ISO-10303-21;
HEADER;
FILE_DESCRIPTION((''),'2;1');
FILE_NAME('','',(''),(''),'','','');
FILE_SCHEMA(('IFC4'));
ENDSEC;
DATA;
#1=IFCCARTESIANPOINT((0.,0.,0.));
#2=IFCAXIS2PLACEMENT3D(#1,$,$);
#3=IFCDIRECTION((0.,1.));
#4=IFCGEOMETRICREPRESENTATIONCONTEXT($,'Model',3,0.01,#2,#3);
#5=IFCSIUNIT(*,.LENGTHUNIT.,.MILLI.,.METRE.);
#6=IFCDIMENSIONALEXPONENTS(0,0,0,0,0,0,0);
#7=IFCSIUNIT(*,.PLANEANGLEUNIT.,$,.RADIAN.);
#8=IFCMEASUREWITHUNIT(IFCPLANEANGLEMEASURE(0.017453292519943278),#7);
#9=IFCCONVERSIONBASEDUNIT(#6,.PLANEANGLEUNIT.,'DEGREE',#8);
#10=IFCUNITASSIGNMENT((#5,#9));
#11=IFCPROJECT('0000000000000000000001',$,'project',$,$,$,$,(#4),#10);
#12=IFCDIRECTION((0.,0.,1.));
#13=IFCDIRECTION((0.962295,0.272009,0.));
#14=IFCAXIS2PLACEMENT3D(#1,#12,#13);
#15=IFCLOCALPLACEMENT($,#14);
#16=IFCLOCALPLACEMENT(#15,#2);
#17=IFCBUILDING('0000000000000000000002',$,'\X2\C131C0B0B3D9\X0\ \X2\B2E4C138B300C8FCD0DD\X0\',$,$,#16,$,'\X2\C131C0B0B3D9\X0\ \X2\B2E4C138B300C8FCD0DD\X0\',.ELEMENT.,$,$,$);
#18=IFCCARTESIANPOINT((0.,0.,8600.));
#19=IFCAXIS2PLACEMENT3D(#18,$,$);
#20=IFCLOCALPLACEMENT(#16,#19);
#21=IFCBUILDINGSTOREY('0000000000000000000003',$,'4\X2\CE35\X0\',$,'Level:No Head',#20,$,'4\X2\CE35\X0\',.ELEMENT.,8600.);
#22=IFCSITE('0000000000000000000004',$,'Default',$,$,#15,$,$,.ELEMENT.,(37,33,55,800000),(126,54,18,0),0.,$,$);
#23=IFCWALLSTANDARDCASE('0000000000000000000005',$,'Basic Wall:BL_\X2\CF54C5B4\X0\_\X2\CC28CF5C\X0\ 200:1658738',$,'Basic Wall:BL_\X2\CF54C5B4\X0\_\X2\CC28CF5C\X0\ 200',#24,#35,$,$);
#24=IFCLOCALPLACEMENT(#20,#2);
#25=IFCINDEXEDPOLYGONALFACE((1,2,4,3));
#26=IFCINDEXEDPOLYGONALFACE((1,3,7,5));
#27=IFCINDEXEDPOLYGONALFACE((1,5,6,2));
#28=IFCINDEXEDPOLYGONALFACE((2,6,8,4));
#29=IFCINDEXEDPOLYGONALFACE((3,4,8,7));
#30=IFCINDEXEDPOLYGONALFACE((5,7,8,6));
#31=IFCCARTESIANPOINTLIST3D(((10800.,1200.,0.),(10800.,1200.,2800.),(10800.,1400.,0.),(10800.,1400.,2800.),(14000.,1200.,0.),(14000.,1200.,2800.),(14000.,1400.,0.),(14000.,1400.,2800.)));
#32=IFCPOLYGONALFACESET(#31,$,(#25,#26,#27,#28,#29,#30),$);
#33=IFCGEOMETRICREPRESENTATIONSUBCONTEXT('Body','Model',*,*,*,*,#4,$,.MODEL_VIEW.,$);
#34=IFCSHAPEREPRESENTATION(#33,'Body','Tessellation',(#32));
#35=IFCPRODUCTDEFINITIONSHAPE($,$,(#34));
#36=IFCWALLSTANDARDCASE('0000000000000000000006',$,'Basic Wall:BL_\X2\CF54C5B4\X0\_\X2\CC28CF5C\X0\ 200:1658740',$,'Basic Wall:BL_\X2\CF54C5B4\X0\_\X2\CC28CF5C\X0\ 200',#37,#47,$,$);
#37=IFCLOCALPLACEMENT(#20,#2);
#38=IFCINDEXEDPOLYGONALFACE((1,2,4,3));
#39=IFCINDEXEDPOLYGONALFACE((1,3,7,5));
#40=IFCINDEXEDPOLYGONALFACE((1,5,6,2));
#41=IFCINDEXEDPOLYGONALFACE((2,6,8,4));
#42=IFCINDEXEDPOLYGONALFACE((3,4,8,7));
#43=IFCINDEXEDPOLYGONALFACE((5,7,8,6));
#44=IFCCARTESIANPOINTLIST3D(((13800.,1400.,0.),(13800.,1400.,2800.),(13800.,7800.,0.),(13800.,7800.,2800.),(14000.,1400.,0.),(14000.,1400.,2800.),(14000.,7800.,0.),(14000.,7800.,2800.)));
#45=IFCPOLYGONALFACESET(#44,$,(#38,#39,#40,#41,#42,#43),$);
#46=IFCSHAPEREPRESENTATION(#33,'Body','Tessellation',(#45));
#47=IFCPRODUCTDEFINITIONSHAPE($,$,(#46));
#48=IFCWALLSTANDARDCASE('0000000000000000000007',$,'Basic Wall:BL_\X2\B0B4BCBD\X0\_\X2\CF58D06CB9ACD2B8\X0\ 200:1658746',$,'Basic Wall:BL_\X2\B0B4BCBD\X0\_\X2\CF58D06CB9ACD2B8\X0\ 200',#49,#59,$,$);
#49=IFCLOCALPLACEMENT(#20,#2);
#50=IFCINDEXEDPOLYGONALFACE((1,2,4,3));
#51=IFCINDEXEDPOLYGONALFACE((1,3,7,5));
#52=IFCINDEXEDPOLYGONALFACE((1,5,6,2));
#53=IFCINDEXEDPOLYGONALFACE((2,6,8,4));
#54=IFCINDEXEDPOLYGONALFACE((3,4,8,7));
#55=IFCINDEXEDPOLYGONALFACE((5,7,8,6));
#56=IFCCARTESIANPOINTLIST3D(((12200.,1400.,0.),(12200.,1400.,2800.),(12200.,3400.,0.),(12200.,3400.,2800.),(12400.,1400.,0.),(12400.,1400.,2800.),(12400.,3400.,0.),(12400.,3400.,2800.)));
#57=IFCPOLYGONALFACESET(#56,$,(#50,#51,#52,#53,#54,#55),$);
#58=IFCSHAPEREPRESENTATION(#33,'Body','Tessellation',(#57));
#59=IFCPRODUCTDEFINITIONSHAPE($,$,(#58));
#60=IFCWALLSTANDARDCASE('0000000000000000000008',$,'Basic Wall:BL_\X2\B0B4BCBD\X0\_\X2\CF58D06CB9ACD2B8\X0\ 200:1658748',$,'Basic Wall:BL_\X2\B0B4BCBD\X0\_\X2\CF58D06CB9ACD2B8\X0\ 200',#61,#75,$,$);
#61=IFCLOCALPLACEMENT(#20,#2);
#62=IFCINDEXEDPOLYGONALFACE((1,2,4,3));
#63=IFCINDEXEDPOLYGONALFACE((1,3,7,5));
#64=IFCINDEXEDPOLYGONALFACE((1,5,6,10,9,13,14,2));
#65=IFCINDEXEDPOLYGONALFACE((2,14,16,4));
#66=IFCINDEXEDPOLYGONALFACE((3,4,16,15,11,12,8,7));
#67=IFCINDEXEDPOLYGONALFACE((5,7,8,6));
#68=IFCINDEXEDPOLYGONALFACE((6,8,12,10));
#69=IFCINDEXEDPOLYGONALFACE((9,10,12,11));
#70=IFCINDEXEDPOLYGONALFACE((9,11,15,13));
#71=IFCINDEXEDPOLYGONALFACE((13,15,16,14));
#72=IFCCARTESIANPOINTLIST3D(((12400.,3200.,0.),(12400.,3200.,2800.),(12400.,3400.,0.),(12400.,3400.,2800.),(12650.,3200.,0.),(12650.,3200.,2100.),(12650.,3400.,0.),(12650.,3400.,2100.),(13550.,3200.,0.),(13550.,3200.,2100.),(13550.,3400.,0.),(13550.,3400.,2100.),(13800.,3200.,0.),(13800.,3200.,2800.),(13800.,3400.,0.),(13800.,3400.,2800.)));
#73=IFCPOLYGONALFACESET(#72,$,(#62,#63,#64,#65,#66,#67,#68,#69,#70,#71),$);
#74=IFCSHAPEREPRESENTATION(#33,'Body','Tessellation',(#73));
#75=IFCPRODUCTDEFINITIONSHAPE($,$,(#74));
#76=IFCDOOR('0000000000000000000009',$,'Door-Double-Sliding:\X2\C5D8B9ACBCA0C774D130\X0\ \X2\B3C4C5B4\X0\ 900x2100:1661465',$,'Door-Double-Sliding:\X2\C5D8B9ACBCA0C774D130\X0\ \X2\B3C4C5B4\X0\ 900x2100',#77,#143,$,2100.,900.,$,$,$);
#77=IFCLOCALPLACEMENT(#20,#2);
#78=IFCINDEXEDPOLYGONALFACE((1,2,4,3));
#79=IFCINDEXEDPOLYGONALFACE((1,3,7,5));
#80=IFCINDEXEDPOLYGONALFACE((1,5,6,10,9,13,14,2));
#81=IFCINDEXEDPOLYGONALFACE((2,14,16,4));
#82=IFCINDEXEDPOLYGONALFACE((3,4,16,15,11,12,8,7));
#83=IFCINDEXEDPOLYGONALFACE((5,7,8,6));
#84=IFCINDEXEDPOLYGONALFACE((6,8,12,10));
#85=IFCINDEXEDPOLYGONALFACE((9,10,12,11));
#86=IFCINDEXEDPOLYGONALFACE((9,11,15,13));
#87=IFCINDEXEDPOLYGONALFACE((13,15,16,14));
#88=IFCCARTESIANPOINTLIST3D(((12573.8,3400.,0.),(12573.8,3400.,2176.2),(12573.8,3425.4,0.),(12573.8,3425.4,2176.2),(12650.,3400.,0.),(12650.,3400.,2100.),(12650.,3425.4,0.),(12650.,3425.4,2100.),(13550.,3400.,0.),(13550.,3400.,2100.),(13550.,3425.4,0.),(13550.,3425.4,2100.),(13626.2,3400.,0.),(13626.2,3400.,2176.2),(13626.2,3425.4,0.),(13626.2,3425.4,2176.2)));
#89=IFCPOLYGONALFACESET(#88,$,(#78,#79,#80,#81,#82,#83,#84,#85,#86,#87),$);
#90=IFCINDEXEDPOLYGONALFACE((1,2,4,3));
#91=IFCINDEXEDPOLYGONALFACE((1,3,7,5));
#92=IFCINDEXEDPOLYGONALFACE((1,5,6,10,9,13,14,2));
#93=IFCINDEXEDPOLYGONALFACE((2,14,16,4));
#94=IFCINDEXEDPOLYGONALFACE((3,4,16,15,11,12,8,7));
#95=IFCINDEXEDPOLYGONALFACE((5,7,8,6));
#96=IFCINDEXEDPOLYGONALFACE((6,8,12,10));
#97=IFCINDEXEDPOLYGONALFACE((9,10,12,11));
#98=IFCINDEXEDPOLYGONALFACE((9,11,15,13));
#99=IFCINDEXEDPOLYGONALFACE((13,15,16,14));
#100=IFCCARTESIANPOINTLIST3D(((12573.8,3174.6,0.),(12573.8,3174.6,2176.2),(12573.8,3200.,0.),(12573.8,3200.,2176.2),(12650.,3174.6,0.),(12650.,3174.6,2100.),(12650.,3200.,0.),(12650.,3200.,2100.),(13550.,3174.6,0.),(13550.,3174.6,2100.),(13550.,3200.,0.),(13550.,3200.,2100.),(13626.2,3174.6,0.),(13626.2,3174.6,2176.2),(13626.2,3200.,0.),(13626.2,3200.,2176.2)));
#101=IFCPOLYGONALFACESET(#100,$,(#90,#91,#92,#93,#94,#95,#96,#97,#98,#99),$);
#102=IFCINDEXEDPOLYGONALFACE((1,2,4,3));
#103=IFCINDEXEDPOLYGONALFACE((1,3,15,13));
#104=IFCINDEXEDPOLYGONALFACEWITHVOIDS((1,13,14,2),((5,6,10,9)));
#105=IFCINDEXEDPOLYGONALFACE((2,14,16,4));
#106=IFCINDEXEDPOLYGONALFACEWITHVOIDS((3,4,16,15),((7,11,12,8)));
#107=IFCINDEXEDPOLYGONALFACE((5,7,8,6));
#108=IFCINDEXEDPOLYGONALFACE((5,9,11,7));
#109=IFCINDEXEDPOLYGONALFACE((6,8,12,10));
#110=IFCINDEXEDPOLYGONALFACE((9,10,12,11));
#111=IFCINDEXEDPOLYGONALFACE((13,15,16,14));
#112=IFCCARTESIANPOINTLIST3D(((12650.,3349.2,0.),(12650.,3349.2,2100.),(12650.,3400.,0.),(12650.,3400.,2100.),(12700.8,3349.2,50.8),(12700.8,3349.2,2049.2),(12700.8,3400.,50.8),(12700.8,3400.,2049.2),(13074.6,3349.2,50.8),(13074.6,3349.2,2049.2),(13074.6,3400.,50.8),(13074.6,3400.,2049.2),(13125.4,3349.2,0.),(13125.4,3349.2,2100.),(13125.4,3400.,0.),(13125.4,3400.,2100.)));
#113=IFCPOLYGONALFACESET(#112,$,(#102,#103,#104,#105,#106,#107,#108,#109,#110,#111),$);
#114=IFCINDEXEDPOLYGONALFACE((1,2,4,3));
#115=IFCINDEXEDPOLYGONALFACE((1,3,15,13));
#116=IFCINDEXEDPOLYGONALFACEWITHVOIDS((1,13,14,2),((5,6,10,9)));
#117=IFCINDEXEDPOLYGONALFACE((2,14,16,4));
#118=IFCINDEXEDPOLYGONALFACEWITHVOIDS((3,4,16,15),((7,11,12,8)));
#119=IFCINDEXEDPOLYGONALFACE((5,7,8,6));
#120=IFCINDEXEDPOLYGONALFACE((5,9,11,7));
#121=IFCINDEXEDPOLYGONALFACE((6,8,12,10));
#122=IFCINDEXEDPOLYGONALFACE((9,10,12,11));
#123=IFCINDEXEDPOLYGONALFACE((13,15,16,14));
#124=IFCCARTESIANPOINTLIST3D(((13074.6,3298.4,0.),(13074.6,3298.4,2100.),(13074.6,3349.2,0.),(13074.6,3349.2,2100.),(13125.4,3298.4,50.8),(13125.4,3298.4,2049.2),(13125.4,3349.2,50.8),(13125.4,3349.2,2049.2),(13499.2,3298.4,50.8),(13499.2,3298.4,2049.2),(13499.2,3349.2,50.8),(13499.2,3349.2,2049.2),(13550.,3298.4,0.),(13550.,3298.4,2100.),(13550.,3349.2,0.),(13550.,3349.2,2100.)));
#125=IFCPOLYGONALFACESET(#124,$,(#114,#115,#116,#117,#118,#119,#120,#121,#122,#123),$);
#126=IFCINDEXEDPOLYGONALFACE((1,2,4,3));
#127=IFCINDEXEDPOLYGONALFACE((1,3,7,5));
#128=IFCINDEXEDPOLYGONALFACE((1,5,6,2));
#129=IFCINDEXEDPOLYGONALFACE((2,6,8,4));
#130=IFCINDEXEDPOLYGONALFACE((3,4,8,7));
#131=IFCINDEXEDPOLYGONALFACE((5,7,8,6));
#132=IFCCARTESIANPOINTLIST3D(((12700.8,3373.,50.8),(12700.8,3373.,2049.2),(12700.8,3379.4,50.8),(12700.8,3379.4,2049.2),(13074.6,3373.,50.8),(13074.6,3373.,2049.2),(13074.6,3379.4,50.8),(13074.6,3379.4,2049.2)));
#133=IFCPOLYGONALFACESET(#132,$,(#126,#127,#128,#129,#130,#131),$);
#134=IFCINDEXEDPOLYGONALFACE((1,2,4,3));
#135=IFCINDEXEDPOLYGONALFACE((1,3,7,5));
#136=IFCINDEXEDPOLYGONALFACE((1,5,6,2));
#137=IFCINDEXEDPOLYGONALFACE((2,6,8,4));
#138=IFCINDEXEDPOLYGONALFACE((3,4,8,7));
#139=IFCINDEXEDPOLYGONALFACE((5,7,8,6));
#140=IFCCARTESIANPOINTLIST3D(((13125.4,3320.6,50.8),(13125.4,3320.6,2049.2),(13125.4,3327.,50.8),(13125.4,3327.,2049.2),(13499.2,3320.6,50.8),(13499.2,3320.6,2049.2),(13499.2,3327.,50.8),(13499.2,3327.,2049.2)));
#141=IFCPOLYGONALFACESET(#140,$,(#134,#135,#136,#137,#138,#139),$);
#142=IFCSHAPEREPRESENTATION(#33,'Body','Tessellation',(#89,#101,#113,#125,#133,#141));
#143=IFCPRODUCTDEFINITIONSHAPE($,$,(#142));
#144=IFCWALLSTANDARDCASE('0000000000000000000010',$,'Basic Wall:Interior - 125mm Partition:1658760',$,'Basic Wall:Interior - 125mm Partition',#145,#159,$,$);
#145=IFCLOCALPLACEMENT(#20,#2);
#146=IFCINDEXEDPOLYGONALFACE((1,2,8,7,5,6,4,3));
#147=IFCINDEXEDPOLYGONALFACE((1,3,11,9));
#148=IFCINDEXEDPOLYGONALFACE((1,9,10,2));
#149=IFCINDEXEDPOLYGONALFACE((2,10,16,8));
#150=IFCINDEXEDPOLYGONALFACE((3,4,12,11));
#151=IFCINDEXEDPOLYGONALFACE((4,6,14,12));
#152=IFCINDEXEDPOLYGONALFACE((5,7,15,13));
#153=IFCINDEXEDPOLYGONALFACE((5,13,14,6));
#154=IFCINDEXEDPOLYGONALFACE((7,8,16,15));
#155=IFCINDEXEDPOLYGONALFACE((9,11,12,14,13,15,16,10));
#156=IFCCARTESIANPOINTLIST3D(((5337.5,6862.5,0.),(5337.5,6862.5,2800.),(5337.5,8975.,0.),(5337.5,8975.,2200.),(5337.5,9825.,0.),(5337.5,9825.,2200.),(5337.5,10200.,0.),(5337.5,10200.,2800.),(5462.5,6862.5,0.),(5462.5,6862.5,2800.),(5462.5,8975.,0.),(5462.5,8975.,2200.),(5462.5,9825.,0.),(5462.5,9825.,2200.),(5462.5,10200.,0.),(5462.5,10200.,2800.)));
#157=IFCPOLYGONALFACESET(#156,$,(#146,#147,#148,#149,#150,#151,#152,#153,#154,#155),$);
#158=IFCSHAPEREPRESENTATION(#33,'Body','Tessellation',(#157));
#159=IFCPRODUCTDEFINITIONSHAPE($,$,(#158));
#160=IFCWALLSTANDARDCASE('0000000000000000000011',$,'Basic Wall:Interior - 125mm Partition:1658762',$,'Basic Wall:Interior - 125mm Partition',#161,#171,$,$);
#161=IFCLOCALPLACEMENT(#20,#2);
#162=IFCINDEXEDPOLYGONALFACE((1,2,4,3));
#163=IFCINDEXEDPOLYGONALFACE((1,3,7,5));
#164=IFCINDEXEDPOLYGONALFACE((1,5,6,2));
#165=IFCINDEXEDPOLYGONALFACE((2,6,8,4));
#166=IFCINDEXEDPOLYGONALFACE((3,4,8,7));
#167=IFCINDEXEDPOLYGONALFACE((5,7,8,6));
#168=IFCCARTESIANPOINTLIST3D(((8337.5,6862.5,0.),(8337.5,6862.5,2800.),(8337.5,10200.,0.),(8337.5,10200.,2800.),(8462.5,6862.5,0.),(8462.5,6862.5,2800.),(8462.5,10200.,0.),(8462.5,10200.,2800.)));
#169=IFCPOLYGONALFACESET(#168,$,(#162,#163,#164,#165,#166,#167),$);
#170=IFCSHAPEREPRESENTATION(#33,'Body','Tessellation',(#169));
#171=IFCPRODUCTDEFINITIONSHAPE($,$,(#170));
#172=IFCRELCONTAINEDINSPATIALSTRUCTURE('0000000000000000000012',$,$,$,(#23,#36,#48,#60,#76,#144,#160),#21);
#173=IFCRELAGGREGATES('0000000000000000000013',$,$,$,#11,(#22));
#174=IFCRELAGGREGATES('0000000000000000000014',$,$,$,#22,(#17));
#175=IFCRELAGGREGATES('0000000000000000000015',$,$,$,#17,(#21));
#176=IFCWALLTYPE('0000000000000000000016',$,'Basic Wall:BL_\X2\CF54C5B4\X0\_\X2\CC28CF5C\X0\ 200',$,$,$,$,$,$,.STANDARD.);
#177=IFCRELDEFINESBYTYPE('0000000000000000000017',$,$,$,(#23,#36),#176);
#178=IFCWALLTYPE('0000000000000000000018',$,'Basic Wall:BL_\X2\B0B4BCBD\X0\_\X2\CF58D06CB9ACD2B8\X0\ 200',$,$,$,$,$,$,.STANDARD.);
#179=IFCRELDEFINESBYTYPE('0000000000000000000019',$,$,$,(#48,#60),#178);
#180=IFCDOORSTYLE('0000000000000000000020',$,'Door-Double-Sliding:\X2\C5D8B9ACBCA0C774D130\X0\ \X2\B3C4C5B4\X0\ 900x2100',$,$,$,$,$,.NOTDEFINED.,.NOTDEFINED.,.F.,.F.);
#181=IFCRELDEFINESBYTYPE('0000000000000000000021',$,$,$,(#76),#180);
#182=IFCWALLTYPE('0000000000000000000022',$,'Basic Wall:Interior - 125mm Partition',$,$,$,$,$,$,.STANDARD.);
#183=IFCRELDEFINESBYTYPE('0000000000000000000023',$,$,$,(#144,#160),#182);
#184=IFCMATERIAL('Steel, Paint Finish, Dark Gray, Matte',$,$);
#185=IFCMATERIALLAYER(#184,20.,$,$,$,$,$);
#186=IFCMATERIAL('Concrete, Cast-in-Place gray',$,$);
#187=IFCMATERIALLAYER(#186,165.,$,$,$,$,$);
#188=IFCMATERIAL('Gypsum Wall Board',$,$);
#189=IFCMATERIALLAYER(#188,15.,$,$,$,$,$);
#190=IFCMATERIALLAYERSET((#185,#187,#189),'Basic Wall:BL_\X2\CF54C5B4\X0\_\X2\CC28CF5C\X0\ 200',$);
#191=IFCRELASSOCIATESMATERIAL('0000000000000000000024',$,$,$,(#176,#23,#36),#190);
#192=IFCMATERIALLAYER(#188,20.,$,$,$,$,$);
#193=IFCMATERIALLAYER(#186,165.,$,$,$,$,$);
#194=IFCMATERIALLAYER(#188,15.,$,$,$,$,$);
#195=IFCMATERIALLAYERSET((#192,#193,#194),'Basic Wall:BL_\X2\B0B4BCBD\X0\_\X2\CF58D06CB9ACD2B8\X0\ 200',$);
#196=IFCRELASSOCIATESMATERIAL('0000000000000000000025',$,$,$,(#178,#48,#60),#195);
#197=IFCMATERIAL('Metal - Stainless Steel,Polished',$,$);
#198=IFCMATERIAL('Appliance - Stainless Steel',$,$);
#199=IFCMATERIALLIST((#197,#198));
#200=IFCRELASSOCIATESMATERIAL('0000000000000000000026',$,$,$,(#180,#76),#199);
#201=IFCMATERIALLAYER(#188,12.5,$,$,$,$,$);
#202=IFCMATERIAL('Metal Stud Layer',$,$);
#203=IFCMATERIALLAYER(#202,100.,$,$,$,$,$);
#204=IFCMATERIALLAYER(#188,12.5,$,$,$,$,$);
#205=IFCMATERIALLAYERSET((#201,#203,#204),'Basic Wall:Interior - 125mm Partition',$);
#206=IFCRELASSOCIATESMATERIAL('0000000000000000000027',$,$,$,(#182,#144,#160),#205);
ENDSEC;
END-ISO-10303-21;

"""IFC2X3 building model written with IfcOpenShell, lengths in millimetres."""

from ifc_helpers import new_model, entity, si_unit, converted_unit, direction, frame, frame_2d, origin, place, context, subcontext, project, spatial, polyline, rectangle, outline, extrude, source, transform, mapped, material, material_list, layer, layer_set, layer_usage, type_object, type_shapes, element, fill, save


model = new_model("IFC2X3")

# Units and contexts
model_context = context("Model", 3, precision=0.01, world=origin(), true_north=direction((0.0, 1.0)))
body_context = subcontext(model_context, "Body", "Model", "MODEL_VIEW")
ifc_project = project(units=[si_unit("LENGTHUNIT", "METRE", prefix="MILLI"), converted_unit("PLANEANGLEUNIT", "DEGREE", entity("IfcPlaneAngleMeasure", 0.017453292519943278), si_unit("PLANEANGLEUNIT", "RADIAN"), dimensions=[0, 0, 0, 0, 0, 0, 0])], contexts=[model_context])

# Site, building, storey
site_placement = place(None, frame((0.0, 0.0, 0.0), z_axis=(0.0, 0.0, 1.0), x_axis=(0.962295, 0.272009, 0.0)))
site = spatial("IfcSite", under=ifc_project, at=site_placement, Name="Default", CompositionType="ELEMENT", RefLatitude=(37, 33, 55, 800000), RefLongitude=(126, 54, 18, 0), RefElevation=0.0)
building_placement = place(site_placement, origin())
building = spatial("IfcBuilding", under=site, at=building_placement, Name="성산동 다세대주택", LongName="성산동 다세대주택", CompositionType="ELEMENT")
storey_placement = place(building_placement, frame((0.0, 0.0, 8600.0)))
storey = spatial("IfcBuildingStorey", under=building, at=storey_placement, Name="4층", ObjectType="Level:No Head", LongName="4층", CompositionType="ELEMENT", Elevation=8600.0)

# Walls
ifc_material_1 = material(Name="Steel, Paint Finish, Dark Gray, Matte")
ifc_layer_1 = layer(ifc_material_1, 20.0)
ifc_material_2 = material(Name="Concrete, Cast-in-Place gray")
ifc_layer_2 = layer(ifc_material_2, 165.0)
ifc_material_3 = material(Name="Gypsum Wall Board")
ifc_layer_3 = layer(ifc_material_3, 15.0)
ifc_layer_set_1 = layer_set([ifc_layer_1, ifc_layer_2, ifc_layer_3], Name="Basic Wall:BL_코어_차콜 200")
ifc_layer_usage_1 = layer_usage(ifc_layer_set_1, "AXIS2", "POSITIVE", -100.0)
wall_type_1 = type_object("IfcWallType", Name="Basic Wall:BL_코어_차콜 200", PredefinedType="STANDARD", material=ifc_layer_set_1)
wall_1_placement = place(storey_placement, frame((10800.0, 1300.0, 0.0)))
element("IfcWallStandardCase", 1, at=wall_1_placement, inside=storey, type_object=wall_type_1, material=ifc_layer_usage_1, Name="Basic Wall:BL_코어_차콜 200:1658738", ObjectType="Basic Wall:BL_코어_차콜 200", context=body_context, shape_type="SweptSolid", body=[
    extrude(rectangle(XDim=3200.0, YDim=200.0, at=frame_2d((1600.0, 0.0), x_axis=(-1.0, 0.0))), origin(), (0.0, 0.0, 1.0), 2800.0),
])
ifc_layer_usage_2 = layer_usage(ifc_layer_set_1, "AXIS2", "POSITIVE", -100.0)
wall_2_placement = place(storey_placement, frame((13900.0, 1400.0, 0.0), z_axis=(0.0, 0.0, 1.0), x_axis=(0.0, 1.0, 0.0)))
element("IfcWallStandardCase", 2, at=wall_2_placement, inside=storey, type_object=wall_type_1, material=ifc_layer_usage_2, Name="Basic Wall:BL_코어_차콜 200:1658740", ObjectType="Basic Wall:BL_코어_차콜 200", context=body_context, shape_type="SweptSolid", body=[
    extrude(rectangle(XDim=6400.0, YDim=200.0, at=frame_2d((3200.0, 0.0), x_axis=(-1.0, 0.0))), origin(), (0.0, 0.0, 1.0), 2800.0),
])
ifc_layer_4 = layer(ifc_material_3, 20.0)
ifc_layer_5 = layer(ifc_material_2, 165.0)
ifc_layer_6 = layer(ifc_material_3, 15.0)
ifc_layer_set_2 = layer_set([ifc_layer_4, ifc_layer_5, ifc_layer_6], Name="Basic Wall:BL_내벽_콘크리트 200")
ifc_layer_usage_3 = layer_usage(ifc_layer_set_2, "AXIS2", "NEGATIVE", 100.0)
wall_type_2 = type_object("IfcWallType", Name="Basic Wall:BL_내벽_콘크리트 200", PredefinedType="STANDARD", material=ifc_layer_set_2)
wall_3_placement = place(storey_placement, frame((12300.0, 1400.0, 0.0), z_axis=(0.0, 0.0, 1.0), x_axis=(0.0, 1.0, 0.0)))
element("IfcWallStandardCase", 3, at=wall_3_placement, inside=storey, type_object=wall_type_2, material=ifc_layer_usage_3, Name="Basic Wall:BL_내벽_콘크리트 200:1658746", ObjectType="Basic Wall:BL_내벽_콘크리트 200", context=body_context, shape_type="SweptSolid", body=[
    extrude(rectangle(XDim=2000.0, YDim=200.0, at=frame_2d((1000.0, 0.0), x_axis=(-1.0, 0.0))), origin(), (0.0, 0.0, 1.0), 2800.0),
])

# Wall, opening, door
ifc_layer_usage_4 = layer_usage(ifc_layer_set_2, "AXIS2", "NEGATIVE", 100.0)
wall_4_placement = place(storey_placement, frame((12400.0, 3300.0, 0.0)))
wall_4 = element("IfcWallStandardCase", 4, at=wall_4_placement, inside=storey, type_object=wall_type_2, material=ifc_layer_usage_4, Name="Basic Wall:BL_내벽_콘크리트 200:1658748", ObjectType="Basic Wall:BL_내벽_콘크리트 200", context=body_context, shape_type="SweptSolid", body=[
    extrude(rectangle(XDim=1400.0, YDim=200.0, at=frame_2d((700.0, 0.0), x_axis=(-1.0, 0.0))), origin(), (0.0, 0.0, 1.0), 2800.0),
])
opening_1_placement = place(wall_4_placement, frame((250.0, -100.0, 0.0)))
opening_1 = element("IfcOpeningElement", 5, at=opening_1_placement, cuts=wall_4, ObjectType="Opening", context=body_context, shape_type="SweptSolid", body=[
    extrude(rectangle(XDim=2100.0, YDim=900.0, at=frame_2d((1050.0, 450.0), x_axis=(-1.0, 0.0))), frame((0.0, 0.0, 0.0), z_axis=(0.0, 1.0, 0.0), x_axis=(0.0, 0.0, 1.0)), (0.0, 0.0, 1.0), 200.0),
])
ifc_material_4 = material(Name="Metal - Stainless Steel,Polished")
ifc_material_5 = material(Name="Appliance - Stainless Steel")
ifc_material_list_1 = material_list([ifc_material_4, ifc_material_5])
door_style = type_object("IfcDoorStyle", Name="Door-Double-Sliding:엘리베이터 도어 900x2100", ConstructionType="NOTDEFINED", OperationType="NOTDEFINED", ParameterTakesPrecedence=False, Sizeable=False, material=ifc_material_list_1)
shared_shape_1 = source(origin(), body_context, "Body", "SweptSolid", [
    extrude(outline(polyline([(-526.2, -1069.1), (-450.0, -1069.1), (-450.0, 1030.9), (450.0, 1031.0), (450.0, -1069.0), (526.2, -1069.0), (526.2, 1107.1), (-526.2, 1107.1), (-526.2, -1069.1)])), frame((450.0, 200.0, 1069.0), z_axis=(0.0, 1.0, 0.0), x_axis=(-1.0, 0.0, 0.0)), (0.0, 0.0, 1.0), 25.4),
    extrude(outline(polyline([(-1069.0, -526.2), (1107.1, -526.2), (1107.1, 526.2), (-1069.0, 526.2), (-1069.0, 450.0), (1030.9, 450.0), (1030.9, -450.0), (-1069.0, -450.0), (-1069.0, -526.2)])), frame((450.0, -25.4, 1069.0), z_axis=(0.0, 1.0, 0.0), x_axis=(0.0, 0.0, 1.0)), (0.0, 0.0, 1.0), 25.4),
    extrude(outline(polyline([(-1050.0, -237.7), (1050.0, -237.7), (1050.0, 237.7), (-1050.0, 237.7), (-1050.0, -237.7)]), holes=[polyline([(-999.2, -186.9), (-999.2, 186.9), (999.2, 186.9), (999.2, -186.9), (-999.2, -186.9)])]), frame((237.7, 149.2, 1050.0), z_axis=(0.0, 1.0, 0.0), x_axis=(0.0, 0.0, -1.0)), (0.0, 0.0, 1.0), 50.8),
    extrude(outline(polyline([(-237.7, -1050.0), (237.7, -1050.0), (237.7, 1050.0), (-237.7, 1050.0), (-237.7, -1050.0)]), holes=[polyline([(-186.9, -999.2), (-186.9, 999.2), (186.9, 999.2), (186.9, -999.2), (-186.9, -999.2)])]), frame((662.3, 98.4, 1050.0), z_axis=(0.0, 1.0, 0.0), x_axis=(1.0, 0.0, 0.0)), (0.0, 0.0, 1.0), 50.8),
    extrude(rectangle(XDim=6.4, YDim=373.8, at=frame_2d((0.0, 0.0), x_axis=(1.0, 0.0))), frame((237.7, 176.2, 50.8), z_axis=(0.0, 0.0, 1.0), x_axis=(0.0, 1.0, 0.0)), (0.0, 0.0, 1.0), 1998.4),
    extrude(rectangle(XDim=6.3, YDim=373.8, at=frame_2d((0.0, 0.0), x_axis=(1.0, 0.0))), frame((662.3, 123.8, 50.8), z_axis=(0.0, 0.0, 1.0), x_axis=(0.0, -1.0, 0.0)), (0.0, 0.0, 1.0), 1998.4),
])
type_shapes(door_style, [shared_shape_1])
door_placement = place(opening_1_placement, origin())
door = element("IfcDoor", 6, at=door_placement, inside=storey, type_object=door_style, material=ifc_material_list_1, Name="Door-Double-Sliding:엘리베이터 도어 900x2100:1661465", ObjectType="Door-Double-Sliding:엘리베이터 도어 900x2100", OverallHeight=2100.0, OverallWidth=900.0, context=body_context, shape_type="MappedRepresentation", body=[
    mapped(shared_shape_1, transform((0.0, 0.0, 0.0), scale=1.0)),
])
fill(opening_1, door)

# Wall, opening
ifc_layer_7 = layer(ifc_material_3, 12.5)
ifc_material_6 = material(Name="Metal Stud Layer")
ifc_layer_8 = layer(ifc_material_6, 100.0)
ifc_layer_9 = layer(ifc_material_3, 12.5)
ifc_layer_set_3 = layer_set([ifc_layer_7, ifc_layer_8, ifc_layer_9], Name="Basic Wall:Interior - 125mm Partition")
ifc_layer_usage_5 = layer_usage(ifc_layer_set_3, "AXIS2", "NEGATIVE", 62.5)
wall_type_3 = type_object("IfcWallType", Name="Basic Wall:Interior - 125mm Partition", PredefinedType="STANDARD", material=ifc_layer_set_3)
wall_5_placement = place(storey_placement, frame((5400.0, 6862.5, 0.0), z_axis=(0.0, 0.0, 1.0), x_axis=(0.0, 1.0, 0.0)))
wall_5 = element("IfcWallStandardCase", 7, at=wall_5_placement, inside=storey, type_object=wall_type_3, material=ifc_layer_usage_5, Name="Basic Wall:Interior - 125mm Partition:1658760", ObjectType="Basic Wall:Interior - 125mm Partition", context=body_context, shape_type="SweptSolid", body=[
    extrude(rectangle(XDim=3337.5, YDim=125.0, at=frame_2d((1668.7, 0.0), x_axis=(1.0, 0.0))), origin(), (0.0, 0.0, 1.0), 2800.0),
])
opening_2_placement = place(wall_5_placement, frame((2112.5, -62.5, 0.0)))
element("IfcOpeningElement", 8, at=opening_2_placement, cuts=wall_5, ObjectType="Opening", context=body_context, shape_type="SweptSolid", body=[
    extrude(rectangle(XDim=2200.0, YDim=850.0, at=frame_2d((1100.0, 425.0), x_axis=(1.0, 0.0))), frame((0.0, 0.0, 0.0), z_axis=(0.0, 1.0, 0.0), x_axis=(0.0, 0.0, 1.0)), (0.0, 0.0, 1.0), 125.0),
])

# Wall
ifc_layer_usage_6 = layer_usage(ifc_layer_set_3, "AXIS2", "NEGATIVE", 62.5)
wall_6_placement = place(storey_placement, frame((8400.0, 6862.5, 0.0), z_axis=(0.0, 0.0, 1.0), x_axis=(0.0, 1.0, 0.0)))
element("IfcWallStandardCase", 9, at=wall_6_placement, inside=storey, type_object=wall_type_3, material=ifc_layer_usage_6, Name="Basic Wall:Interior - 125mm Partition:1658762", ObjectType="Basic Wall:Interior - 125mm Partition", context=body_context, shape_type="SweptSolid", body=[
    extrude(rectangle(XDim=3337.5, YDim=125.0, at=frame_2d((1668.7, 0.0), x_axis=(-1.0, 0.0))), origin(), (0.0, 0.0, 1.0), 2800.0),
])

save(model, "model.ifc")
